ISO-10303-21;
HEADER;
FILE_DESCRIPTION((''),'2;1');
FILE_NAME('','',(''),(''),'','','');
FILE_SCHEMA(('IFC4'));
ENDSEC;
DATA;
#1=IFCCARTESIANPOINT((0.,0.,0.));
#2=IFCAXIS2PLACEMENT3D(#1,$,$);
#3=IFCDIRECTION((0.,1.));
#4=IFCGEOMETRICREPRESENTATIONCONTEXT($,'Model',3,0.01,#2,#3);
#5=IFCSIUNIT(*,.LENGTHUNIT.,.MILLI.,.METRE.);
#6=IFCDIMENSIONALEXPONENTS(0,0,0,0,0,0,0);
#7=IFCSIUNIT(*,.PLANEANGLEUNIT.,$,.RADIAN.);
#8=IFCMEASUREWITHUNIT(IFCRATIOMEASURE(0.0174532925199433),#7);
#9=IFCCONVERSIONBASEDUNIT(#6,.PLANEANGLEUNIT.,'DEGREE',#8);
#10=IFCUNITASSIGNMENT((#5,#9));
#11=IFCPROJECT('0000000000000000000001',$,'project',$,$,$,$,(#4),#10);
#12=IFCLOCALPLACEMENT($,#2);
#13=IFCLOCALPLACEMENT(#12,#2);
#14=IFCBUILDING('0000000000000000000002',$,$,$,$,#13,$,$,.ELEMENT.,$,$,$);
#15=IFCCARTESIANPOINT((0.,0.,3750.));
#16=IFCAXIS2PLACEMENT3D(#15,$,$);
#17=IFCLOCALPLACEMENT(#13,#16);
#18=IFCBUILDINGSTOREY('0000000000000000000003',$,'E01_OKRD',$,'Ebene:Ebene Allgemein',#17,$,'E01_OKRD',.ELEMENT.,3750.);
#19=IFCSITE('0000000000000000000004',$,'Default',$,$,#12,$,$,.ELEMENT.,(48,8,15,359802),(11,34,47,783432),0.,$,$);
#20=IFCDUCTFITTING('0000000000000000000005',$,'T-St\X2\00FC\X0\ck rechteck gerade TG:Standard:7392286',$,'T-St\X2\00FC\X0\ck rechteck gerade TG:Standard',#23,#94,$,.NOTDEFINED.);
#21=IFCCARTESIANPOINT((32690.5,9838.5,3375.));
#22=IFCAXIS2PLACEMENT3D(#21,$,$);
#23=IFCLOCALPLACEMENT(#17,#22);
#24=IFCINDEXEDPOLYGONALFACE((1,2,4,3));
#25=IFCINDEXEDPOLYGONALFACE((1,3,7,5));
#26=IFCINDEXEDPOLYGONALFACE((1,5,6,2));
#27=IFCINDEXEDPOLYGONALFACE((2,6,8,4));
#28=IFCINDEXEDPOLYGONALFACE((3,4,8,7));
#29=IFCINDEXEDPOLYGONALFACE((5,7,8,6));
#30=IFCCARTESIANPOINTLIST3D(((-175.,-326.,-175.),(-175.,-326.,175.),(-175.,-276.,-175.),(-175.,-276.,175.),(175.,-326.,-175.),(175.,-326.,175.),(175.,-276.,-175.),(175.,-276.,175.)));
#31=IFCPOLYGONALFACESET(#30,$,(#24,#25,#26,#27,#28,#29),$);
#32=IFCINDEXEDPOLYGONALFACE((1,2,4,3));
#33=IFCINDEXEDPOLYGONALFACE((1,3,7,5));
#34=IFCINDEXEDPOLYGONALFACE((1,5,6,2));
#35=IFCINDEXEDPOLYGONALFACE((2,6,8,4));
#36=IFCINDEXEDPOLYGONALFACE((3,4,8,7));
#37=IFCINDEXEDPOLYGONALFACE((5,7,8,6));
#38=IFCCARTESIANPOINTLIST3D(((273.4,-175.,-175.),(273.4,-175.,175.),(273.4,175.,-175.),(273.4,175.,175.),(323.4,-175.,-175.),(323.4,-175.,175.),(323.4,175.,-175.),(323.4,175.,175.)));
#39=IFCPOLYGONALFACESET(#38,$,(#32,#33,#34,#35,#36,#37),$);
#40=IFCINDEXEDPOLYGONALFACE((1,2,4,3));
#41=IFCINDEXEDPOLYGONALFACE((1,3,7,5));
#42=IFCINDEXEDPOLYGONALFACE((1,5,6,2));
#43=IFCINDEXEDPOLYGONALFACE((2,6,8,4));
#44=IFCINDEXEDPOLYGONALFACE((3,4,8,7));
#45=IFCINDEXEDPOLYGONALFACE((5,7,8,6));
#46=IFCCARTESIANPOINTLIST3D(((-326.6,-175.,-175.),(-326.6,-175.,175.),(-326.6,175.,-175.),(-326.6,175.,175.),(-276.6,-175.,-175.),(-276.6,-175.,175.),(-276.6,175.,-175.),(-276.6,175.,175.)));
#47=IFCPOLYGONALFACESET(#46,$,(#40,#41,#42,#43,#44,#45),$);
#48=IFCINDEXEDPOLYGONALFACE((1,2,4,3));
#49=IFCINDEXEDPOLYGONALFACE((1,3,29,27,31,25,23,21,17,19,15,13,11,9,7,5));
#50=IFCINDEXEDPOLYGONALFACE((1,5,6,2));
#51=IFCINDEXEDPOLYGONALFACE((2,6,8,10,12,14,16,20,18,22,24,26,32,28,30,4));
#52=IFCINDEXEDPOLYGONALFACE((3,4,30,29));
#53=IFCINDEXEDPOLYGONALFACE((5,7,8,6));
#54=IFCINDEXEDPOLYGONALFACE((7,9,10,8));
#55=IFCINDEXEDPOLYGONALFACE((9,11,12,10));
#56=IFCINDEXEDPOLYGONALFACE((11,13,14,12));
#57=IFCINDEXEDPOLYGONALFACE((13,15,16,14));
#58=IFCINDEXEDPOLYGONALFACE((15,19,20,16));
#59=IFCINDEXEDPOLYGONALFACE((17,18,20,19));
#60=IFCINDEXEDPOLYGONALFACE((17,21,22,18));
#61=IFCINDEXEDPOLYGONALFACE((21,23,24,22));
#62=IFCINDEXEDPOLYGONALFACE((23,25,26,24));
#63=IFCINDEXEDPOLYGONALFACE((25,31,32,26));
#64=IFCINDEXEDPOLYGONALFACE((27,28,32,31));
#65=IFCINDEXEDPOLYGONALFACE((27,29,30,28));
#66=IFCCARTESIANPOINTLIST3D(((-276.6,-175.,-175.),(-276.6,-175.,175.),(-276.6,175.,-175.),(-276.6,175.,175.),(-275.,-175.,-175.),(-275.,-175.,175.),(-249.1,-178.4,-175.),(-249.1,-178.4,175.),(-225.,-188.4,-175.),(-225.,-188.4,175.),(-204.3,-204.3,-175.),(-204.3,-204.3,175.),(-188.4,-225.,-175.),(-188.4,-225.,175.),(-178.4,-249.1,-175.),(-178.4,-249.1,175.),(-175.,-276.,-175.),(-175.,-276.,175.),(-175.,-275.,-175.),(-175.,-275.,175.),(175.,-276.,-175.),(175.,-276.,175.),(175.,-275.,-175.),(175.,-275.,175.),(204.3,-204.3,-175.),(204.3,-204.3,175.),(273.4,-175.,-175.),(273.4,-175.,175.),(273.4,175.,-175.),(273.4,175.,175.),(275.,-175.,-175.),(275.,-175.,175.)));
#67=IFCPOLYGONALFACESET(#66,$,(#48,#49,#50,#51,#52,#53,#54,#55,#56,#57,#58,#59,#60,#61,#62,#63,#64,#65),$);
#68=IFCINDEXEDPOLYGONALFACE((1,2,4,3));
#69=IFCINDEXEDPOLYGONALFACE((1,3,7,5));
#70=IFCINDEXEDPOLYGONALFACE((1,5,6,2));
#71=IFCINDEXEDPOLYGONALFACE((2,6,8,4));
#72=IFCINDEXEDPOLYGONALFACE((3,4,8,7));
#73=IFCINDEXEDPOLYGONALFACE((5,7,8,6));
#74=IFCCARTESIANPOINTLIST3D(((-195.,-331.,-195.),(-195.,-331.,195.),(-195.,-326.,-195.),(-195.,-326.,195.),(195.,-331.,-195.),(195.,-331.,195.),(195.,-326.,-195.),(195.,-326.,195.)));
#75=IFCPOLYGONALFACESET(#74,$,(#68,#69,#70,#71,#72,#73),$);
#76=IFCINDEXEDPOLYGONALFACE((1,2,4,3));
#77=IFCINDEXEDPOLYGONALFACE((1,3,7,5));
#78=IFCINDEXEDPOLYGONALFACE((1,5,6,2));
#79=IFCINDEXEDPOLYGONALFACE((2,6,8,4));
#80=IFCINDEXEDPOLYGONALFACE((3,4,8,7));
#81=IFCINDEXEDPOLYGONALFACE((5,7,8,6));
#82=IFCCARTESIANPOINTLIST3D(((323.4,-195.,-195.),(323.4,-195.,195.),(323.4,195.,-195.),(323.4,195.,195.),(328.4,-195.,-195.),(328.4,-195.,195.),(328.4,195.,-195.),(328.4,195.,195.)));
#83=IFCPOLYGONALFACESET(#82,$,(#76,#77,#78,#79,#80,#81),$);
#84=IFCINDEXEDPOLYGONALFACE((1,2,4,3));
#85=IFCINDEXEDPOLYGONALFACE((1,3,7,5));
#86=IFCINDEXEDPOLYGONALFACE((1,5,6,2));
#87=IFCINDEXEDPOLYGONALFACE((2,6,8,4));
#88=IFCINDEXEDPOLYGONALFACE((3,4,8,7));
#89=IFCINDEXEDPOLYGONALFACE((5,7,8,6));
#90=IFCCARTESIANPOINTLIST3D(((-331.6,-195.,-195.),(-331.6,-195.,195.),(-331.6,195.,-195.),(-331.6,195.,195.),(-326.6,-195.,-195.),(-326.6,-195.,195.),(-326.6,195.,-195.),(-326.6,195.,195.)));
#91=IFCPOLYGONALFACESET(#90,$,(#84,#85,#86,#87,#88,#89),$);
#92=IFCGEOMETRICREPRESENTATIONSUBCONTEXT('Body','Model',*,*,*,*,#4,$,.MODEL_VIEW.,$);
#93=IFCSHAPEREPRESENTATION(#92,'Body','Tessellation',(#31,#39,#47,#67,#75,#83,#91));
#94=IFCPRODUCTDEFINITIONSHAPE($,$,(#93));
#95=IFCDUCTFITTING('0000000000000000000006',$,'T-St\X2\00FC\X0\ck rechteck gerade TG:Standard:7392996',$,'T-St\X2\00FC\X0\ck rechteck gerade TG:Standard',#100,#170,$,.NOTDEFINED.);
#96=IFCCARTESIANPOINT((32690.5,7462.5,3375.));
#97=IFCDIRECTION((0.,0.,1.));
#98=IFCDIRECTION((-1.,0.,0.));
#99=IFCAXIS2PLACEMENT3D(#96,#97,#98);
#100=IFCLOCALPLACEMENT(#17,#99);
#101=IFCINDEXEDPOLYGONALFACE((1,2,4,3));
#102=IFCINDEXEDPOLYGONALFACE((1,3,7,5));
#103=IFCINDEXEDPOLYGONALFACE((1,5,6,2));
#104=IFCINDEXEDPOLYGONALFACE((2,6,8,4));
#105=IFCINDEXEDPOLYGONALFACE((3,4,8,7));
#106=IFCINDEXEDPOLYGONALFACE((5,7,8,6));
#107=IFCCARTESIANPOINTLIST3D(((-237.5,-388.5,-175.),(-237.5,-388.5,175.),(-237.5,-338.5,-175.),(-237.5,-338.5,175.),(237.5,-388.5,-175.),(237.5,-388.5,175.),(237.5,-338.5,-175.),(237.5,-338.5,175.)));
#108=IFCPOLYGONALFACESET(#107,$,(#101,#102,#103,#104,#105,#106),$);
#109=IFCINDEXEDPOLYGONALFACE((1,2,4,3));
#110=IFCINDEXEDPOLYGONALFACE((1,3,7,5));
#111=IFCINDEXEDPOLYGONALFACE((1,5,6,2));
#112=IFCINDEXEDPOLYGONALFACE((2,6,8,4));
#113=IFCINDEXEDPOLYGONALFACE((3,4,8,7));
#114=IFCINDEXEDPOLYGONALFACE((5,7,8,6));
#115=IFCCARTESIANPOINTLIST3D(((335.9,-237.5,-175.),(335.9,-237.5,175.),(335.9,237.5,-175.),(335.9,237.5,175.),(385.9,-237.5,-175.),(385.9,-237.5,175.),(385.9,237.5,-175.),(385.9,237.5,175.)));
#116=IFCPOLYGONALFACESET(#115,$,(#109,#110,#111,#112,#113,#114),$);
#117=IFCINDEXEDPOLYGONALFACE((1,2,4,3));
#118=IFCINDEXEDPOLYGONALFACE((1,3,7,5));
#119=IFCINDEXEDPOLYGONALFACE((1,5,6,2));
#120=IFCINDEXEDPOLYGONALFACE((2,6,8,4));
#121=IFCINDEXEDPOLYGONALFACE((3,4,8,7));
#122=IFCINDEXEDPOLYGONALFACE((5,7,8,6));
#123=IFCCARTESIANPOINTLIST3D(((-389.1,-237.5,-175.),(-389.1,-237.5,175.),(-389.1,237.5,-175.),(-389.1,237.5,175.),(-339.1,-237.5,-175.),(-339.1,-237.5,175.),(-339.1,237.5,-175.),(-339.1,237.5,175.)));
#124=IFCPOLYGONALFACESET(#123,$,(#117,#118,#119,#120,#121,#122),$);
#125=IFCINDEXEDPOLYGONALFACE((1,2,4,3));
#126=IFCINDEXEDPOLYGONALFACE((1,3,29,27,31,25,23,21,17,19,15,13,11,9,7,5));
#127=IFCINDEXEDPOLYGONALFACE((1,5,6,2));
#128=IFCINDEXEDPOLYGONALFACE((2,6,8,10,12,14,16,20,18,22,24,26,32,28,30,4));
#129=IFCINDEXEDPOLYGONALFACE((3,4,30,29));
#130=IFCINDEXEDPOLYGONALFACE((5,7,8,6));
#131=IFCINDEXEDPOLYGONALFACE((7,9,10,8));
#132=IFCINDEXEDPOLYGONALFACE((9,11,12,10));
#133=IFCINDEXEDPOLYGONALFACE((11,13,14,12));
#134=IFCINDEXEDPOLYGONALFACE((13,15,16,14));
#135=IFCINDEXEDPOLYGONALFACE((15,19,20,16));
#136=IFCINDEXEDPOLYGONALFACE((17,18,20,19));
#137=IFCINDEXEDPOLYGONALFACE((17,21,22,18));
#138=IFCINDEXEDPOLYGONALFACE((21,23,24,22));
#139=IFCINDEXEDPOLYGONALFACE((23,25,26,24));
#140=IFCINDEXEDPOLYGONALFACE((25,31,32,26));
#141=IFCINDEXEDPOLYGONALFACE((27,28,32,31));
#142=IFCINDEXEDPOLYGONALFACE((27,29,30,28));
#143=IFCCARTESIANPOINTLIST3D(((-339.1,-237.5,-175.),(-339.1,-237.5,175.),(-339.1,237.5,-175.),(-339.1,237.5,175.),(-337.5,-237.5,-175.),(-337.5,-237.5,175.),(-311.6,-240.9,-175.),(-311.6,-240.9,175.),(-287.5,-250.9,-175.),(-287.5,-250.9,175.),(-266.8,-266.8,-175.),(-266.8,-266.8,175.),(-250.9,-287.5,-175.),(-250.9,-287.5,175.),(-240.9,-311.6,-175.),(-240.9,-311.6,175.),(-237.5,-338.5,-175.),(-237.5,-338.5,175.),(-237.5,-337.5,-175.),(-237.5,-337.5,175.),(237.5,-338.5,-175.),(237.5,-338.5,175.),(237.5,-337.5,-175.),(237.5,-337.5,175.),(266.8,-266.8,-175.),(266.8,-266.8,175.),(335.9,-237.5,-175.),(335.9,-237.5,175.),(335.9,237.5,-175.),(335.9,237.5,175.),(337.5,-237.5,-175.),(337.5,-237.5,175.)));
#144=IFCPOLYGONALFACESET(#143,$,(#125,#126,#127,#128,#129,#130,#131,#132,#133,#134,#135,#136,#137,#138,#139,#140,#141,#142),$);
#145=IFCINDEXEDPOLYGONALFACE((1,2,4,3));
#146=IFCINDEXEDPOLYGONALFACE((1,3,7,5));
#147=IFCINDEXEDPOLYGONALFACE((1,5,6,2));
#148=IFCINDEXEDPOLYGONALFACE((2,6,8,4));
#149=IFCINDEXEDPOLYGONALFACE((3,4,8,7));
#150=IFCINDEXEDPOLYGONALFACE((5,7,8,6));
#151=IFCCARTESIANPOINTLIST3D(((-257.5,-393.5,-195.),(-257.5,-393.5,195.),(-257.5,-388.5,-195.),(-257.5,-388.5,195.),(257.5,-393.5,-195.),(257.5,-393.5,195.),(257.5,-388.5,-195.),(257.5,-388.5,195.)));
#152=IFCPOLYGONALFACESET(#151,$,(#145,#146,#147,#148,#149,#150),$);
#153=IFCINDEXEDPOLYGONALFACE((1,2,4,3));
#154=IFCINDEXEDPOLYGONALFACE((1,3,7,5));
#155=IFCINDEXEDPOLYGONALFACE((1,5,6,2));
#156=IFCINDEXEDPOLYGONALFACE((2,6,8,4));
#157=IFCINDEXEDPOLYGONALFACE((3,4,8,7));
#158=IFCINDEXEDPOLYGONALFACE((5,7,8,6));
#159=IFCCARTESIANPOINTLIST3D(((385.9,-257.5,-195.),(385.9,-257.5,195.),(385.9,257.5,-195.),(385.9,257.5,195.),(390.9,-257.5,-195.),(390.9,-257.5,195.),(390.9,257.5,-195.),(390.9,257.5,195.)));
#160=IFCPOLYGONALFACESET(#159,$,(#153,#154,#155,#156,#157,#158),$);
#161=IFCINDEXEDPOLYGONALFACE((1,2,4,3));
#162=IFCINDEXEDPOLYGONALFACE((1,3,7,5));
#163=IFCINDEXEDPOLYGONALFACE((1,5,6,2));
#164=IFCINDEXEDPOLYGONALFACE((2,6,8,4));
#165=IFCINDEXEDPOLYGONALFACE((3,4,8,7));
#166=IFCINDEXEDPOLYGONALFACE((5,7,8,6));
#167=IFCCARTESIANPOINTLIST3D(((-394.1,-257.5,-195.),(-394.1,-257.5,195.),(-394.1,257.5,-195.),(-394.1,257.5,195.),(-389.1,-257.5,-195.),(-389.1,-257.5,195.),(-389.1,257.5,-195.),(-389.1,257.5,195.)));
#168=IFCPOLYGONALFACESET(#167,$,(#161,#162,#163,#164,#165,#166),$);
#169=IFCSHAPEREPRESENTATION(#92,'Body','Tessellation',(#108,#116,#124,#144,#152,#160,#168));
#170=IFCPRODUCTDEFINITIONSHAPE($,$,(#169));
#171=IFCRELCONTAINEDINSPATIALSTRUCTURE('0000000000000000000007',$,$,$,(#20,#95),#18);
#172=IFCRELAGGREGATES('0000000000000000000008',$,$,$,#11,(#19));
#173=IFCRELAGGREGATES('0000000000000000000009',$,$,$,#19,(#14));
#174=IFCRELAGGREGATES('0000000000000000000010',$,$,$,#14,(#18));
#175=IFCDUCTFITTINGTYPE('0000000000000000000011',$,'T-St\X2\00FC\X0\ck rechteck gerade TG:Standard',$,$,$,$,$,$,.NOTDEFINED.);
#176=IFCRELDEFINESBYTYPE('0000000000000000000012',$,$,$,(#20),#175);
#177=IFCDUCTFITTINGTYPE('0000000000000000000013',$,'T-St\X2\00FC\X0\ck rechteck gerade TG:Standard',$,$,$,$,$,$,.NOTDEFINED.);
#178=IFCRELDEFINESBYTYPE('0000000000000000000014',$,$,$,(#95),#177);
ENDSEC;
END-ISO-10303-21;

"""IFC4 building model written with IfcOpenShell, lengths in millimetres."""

from ifc_helpers import new_model, entity, si_unit, converted_unit, direction, frame, frame_2d, origin, origin_2d_with_axis, place, context, subcontext, project, spatial, polyline, circle_curve, parameter, trimmed, segment, composite_curve, rectangle, outline, extrude, source, transform, mapped, type_object, type_shapes, element, save


model = new_model("IFC4")

# Units and contexts
model_context = context("Model", 3, precision=0.01, world=origin(), true_north=direction((0.0, 1.0)))
body_context = subcontext(model_context, "Body", "Model", "MODEL_VIEW")
ifc_project = project(units=[si_unit("LENGTHUNIT", "METRE", prefix="MILLI"), converted_unit("PLANEANGLEUNIT", "DEGREE", entity("IfcRatioMeasure", 0.0174532925199433), si_unit("PLANEANGLEUNIT", "RADIAN"), dimensions=[0, 0, 0, 0, 0, 0, 0])], contexts=[model_context])

# Site, building, storey
site_placement = place(None, origin())
site = spatial("IfcSite", under=ifc_project, at=site_placement, Name="Default", CompositionType="ELEMENT", RefLatitude=(48, 8, 15, 359802), RefLongitude=(11, 34, 47, 783432), RefElevation=0.0)
building_placement = place(site_placement, origin())
building = spatial("IfcBuilding", under=site, at=building_placement, CompositionType="ELEMENT")
storey_placement = place(building_placement, frame((0.0, 0.0, 3750.0)))
storey = spatial("IfcBuildingStorey", under=building, at=storey_placement, Name="E01_OKRD", ObjectType="Ebene:Ebene Allgemein", LongName="E01_OKRD", CompositionType="ELEMENT", Elevation=3750.0)

# Duct fittings
duct_fitting_type_1 = type_object("IfcDuctFittingType", Name="T-Stück rechteck gerade TG:Standard", PredefinedType="NOTDEFINED")
shared_shape_1 = source(origin(), body_context, "Body", "SweptSolid", [
    extrude(rectangle(XDim=50.0, YDim=350.0, at=frame_2d((0.0, 0.0), x_axis=(1.0, 0.0))), frame((0.0, -301.0, -175.0), z_axis=(0.0, 0.0, 1.0), x_axis=(0.0, -1.0, 0.0)), (0.0, 0.0, 1.0), 350.0),
    extrude(rectangle(XDim=50.0, YDim=350.0, at=origin_2d_with_axis()), frame((298.4, 0.0, -175.0), z_axis=(0.0, 0.0, 1.0), x_axis=(-1.0, 0.0, 0.0)), (0.0, 0.0, 1.0), 350.0),
    extrude(rectangle(XDim=50.0, YDim=350.0, at=origin_2d_with_axis()), frame((-301.6, 0.0, -175.0)), (0.0, 0.0, 1.0), 350.0),
    extrude(outline(composite_curve([segment(trimmed(circle_curve(frame_2d((-275.6, -129.8), x_axis=(-1.0, 0.0)), 100.0), [parameter(180.0)], [parameter(270.0)], True, "PARAMETER"), False, "CONTINUOUS"), segment(polyline([(-175.6, -129.8), (-175.6, -130.8)]), True, "CONTINUOUS"), segment(polyline([(-175.6, -130.8), (174.4, -130.8)]), True, "CONTINUOUS"), segment(polyline([(174.4, -130.8), (174.4, -129.8)]), True, "CONTINUOUS"), segment(trimmed(circle_curve(frame_2d((274.4, -129.8), x_axis=(-1.0, 0.0)), 100.0), [parameter(270.0)], [parameter(0.0)], True, "PARAMETER"), False, "CONTINUOUS"), segment(polyline([(274.4, -29.8), (276.0, -29.8)]), True, "CONTINUOUS"), segment(polyline([(276.0, -29.8), (276.0, 320.2)]), True, "CONTINUOUS"), segment(polyline([(276.0, 320.2), (-274.0, 320.2)]), True, "CONTINUOUS"), segment(polyline([(-274.0, 320.2), (-274.0, -29.8)]), True, "CONTINUOUS"), segment(polyline([(-274.0, -29.8), (-275.6, -29.8)]), True, "CONTINUOUS")], self_intersect=False)), frame((-0.6, -145.2, -175.0), z_axis=(0.0, 0.0, -1.0), x_axis=(-1.0, 0.0, 0.0)), (0.0, 0.0, -1.0), 350.0),
    extrude(rectangle(XDim=5.0, YDim=390.0, at=frame_2d((0.0, 0.0), x_axis=(1.0, 0.0))), frame((0.0, -328.5, -195.0), z_axis=(0.0, 0.0, 1.0), x_axis=(0.0, 1.0, 0.0)), (0.0, 0.0, 1.0), 390.0),
    extrude(rectangle(XDim=5.0, YDim=390.0, at=origin_2d_with_axis()), frame((325.9, 0.0, -195.0), z_axis=(0.0, 0.0, 1.0), x_axis=(-1.0, 0.0, 0.0)), (0.0, 0.0, 1.0), 390.0),
    extrude(rectangle(XDim=5.0, YDim=390.0, at=origin_2d_with_axis()), frame((-329.1, 0.0, -195.0), z_axis=(0.0, 0.0, 1.0), x_axis=(-1.0, 0.0, 0.0)), (0.0, 0.0, 1.0), 390.0),
])
type_shapes(duct_fitting_type_1, [shared_shape_1])
duct_fitting_1_placement = place(storey_placement, frame((32690.5, 9838.5, 3375.0)))
element("IfcDuctFitting", 1, at=duct_fitting_1_placement, inside=storey, type_object=duct_fitting_type_1, Name="T-Stück rechteck gerade TG:Standard:7392286", ObjectType="T-Stück rechteck gerade TG:Standard", PredefinedType="NOTDEFINED", context=body_context, shape_type="MappedRepresentation", body=[
    mapped(shared_shape_1, transform((0.0, 0.0, 0.0), scale=1.0)),
])
duct_fitting_type_2 = type_object("IfcDuctFittingType", Name="T-Stück rechteck gerade TG:Standard", PredefinedType="NOTDEFINED")
shared_shape_2 = source(origin(), body_context, "Body", "SweptSolid", [
    extrude(rectangle(XDim=50.0, YDim=475.0, at=origin_2d_with_axis()), frame((0.0, -363.5, -175.0), z_axis=(0.0, 0.0, 1.0), x_axis=(0.0, -1.0, 0.0)), (0.0, 0.0, 1.0), 350.0),
    extrude(rectangle(XDim=50.0, YDim=475.0, at=origin_2d_with_axis()), frame((360.9, 0.0, -175.0), z_axis=(0.0, 0.0, 1.0), x_axis=(-1.0, 0.0, 0.0)), (0.0, 0.0, 1.0), 350.0),
    extrude(rectangle(XDim=50.0, YDim=475.0, at=origin_2d_with_axis()), frame((-364.1, 0.0, -175.0)), (0.0, 0.0, 1.0), 350.0),
    extrude(outline(composite_curve([segment(trimmed(circle_curve(frame_2d((-338.1, -154.8), x_axis=(-1.0, 0.0)), 100.0), [parameter(180.0)], [parameter(270.0)], True, "PARAMETER"), False, "CONTINUOUS"), segment(polyline([(-238.1, -154.8), (-238.1, -155.8)]), True, "CONTINUOUS"), segment(polyline([(-238.1, -155.8), (236.9, -155.8)]), True, "CONTINUOUS"), segment(polyline([(236.9, -155.8), (236.9, -154.8)]), True, "CONTINUOUS"), segment(trimmed(circle_curve(frame_2d((336.9, -154.8), x_axis=(-1.0, 0.0)), 100.0), [parameter(270.0)], [parameter(0.0)], True, "PARAMETER"), False, "CONTINUOUS"), segment(polyline([(336.9, -54.8), (338.5, -54.8)]), True, "CONTINUOUS"), segment(polyline([(338.5, -54.8), (338.5, 420.2)]), True, "CONTINUOUS"), segment(polyline([(338.5, 420.2), (-336.5, 420.2)]), True, "CONTINUOUS"), segment(polyline([(-336.5, 420.2), (-336.5, -54.8)]), True, "CONTINUOUS"), segment(polyline([(-336.5, -54.8), (-338.1, -54.8)]), True, "CONTINUOUS")], self_intersect=False)), frame((-0.6, -182.7, -175.0), z_axis=(0.0, 0.0, -1.0), x_axis=(-1.0, 0.0, 0.0)), (0.0, 0.0, -1.0), 350.0),
    extrude(rectangle(XDim=5.0, YDim=515.0, at=origin_2d_with_axis()), frame((0.0, -391.0, -195.0), z_axis=(0.0, 0.0, 1.0), x_axis=(0.0, 1.0, 0.0)), (0.0, 0.0, 1.0), 390.0),
    extrude(rectangle(XDim=5.0, YDim=515.0, at=origin_2d_with_axis()), frame((388.4, 0.0, -195.0), z_axis=(0.0, 0.0, 1.0), x_axis=(-1.0, 0.0, 0.0)), (0.0, 0.0, 1.0), 390.0),
    extrude(rectangle(XDim=5.0, YDim=515.0, at=origin_2d_with_axis()), frame((-391.6, 0.0, -195.0), z_axis=(0.0, 0.0, 1.0), x_axis=(-1.0, 0.0, 0.0)), (0.0, 0.0, 1.0), 390.0),
])
type_shapes(duct_fitting_type_2, [shared_shape_2])
duct_fitting_2_placement = place(storey_placement, frame((32690.5, 7462.5, 3375.0), z_axis=(0.0, 0.0, 1.0), x_axis=(-1.0, 0.0, 0.0)))
element("IfcDuctFitting", 2, at=duct_fitting_2_placement, inside=storey, type_object=duct_fitting_type_2, Name="T-Stück rechteck gerade TG:Standard:7392996", ObjectType="T-Stück rechteck gerade TG:Standard", PredefinedType="NOTDEFINED", context=body_context, shape_type="MappedRepresentation", body=[
    mapped(shared_shape_2, transform((0.0, 0.0, 0.0), scale=1.0)),
])

save(model, "model.ifc")
